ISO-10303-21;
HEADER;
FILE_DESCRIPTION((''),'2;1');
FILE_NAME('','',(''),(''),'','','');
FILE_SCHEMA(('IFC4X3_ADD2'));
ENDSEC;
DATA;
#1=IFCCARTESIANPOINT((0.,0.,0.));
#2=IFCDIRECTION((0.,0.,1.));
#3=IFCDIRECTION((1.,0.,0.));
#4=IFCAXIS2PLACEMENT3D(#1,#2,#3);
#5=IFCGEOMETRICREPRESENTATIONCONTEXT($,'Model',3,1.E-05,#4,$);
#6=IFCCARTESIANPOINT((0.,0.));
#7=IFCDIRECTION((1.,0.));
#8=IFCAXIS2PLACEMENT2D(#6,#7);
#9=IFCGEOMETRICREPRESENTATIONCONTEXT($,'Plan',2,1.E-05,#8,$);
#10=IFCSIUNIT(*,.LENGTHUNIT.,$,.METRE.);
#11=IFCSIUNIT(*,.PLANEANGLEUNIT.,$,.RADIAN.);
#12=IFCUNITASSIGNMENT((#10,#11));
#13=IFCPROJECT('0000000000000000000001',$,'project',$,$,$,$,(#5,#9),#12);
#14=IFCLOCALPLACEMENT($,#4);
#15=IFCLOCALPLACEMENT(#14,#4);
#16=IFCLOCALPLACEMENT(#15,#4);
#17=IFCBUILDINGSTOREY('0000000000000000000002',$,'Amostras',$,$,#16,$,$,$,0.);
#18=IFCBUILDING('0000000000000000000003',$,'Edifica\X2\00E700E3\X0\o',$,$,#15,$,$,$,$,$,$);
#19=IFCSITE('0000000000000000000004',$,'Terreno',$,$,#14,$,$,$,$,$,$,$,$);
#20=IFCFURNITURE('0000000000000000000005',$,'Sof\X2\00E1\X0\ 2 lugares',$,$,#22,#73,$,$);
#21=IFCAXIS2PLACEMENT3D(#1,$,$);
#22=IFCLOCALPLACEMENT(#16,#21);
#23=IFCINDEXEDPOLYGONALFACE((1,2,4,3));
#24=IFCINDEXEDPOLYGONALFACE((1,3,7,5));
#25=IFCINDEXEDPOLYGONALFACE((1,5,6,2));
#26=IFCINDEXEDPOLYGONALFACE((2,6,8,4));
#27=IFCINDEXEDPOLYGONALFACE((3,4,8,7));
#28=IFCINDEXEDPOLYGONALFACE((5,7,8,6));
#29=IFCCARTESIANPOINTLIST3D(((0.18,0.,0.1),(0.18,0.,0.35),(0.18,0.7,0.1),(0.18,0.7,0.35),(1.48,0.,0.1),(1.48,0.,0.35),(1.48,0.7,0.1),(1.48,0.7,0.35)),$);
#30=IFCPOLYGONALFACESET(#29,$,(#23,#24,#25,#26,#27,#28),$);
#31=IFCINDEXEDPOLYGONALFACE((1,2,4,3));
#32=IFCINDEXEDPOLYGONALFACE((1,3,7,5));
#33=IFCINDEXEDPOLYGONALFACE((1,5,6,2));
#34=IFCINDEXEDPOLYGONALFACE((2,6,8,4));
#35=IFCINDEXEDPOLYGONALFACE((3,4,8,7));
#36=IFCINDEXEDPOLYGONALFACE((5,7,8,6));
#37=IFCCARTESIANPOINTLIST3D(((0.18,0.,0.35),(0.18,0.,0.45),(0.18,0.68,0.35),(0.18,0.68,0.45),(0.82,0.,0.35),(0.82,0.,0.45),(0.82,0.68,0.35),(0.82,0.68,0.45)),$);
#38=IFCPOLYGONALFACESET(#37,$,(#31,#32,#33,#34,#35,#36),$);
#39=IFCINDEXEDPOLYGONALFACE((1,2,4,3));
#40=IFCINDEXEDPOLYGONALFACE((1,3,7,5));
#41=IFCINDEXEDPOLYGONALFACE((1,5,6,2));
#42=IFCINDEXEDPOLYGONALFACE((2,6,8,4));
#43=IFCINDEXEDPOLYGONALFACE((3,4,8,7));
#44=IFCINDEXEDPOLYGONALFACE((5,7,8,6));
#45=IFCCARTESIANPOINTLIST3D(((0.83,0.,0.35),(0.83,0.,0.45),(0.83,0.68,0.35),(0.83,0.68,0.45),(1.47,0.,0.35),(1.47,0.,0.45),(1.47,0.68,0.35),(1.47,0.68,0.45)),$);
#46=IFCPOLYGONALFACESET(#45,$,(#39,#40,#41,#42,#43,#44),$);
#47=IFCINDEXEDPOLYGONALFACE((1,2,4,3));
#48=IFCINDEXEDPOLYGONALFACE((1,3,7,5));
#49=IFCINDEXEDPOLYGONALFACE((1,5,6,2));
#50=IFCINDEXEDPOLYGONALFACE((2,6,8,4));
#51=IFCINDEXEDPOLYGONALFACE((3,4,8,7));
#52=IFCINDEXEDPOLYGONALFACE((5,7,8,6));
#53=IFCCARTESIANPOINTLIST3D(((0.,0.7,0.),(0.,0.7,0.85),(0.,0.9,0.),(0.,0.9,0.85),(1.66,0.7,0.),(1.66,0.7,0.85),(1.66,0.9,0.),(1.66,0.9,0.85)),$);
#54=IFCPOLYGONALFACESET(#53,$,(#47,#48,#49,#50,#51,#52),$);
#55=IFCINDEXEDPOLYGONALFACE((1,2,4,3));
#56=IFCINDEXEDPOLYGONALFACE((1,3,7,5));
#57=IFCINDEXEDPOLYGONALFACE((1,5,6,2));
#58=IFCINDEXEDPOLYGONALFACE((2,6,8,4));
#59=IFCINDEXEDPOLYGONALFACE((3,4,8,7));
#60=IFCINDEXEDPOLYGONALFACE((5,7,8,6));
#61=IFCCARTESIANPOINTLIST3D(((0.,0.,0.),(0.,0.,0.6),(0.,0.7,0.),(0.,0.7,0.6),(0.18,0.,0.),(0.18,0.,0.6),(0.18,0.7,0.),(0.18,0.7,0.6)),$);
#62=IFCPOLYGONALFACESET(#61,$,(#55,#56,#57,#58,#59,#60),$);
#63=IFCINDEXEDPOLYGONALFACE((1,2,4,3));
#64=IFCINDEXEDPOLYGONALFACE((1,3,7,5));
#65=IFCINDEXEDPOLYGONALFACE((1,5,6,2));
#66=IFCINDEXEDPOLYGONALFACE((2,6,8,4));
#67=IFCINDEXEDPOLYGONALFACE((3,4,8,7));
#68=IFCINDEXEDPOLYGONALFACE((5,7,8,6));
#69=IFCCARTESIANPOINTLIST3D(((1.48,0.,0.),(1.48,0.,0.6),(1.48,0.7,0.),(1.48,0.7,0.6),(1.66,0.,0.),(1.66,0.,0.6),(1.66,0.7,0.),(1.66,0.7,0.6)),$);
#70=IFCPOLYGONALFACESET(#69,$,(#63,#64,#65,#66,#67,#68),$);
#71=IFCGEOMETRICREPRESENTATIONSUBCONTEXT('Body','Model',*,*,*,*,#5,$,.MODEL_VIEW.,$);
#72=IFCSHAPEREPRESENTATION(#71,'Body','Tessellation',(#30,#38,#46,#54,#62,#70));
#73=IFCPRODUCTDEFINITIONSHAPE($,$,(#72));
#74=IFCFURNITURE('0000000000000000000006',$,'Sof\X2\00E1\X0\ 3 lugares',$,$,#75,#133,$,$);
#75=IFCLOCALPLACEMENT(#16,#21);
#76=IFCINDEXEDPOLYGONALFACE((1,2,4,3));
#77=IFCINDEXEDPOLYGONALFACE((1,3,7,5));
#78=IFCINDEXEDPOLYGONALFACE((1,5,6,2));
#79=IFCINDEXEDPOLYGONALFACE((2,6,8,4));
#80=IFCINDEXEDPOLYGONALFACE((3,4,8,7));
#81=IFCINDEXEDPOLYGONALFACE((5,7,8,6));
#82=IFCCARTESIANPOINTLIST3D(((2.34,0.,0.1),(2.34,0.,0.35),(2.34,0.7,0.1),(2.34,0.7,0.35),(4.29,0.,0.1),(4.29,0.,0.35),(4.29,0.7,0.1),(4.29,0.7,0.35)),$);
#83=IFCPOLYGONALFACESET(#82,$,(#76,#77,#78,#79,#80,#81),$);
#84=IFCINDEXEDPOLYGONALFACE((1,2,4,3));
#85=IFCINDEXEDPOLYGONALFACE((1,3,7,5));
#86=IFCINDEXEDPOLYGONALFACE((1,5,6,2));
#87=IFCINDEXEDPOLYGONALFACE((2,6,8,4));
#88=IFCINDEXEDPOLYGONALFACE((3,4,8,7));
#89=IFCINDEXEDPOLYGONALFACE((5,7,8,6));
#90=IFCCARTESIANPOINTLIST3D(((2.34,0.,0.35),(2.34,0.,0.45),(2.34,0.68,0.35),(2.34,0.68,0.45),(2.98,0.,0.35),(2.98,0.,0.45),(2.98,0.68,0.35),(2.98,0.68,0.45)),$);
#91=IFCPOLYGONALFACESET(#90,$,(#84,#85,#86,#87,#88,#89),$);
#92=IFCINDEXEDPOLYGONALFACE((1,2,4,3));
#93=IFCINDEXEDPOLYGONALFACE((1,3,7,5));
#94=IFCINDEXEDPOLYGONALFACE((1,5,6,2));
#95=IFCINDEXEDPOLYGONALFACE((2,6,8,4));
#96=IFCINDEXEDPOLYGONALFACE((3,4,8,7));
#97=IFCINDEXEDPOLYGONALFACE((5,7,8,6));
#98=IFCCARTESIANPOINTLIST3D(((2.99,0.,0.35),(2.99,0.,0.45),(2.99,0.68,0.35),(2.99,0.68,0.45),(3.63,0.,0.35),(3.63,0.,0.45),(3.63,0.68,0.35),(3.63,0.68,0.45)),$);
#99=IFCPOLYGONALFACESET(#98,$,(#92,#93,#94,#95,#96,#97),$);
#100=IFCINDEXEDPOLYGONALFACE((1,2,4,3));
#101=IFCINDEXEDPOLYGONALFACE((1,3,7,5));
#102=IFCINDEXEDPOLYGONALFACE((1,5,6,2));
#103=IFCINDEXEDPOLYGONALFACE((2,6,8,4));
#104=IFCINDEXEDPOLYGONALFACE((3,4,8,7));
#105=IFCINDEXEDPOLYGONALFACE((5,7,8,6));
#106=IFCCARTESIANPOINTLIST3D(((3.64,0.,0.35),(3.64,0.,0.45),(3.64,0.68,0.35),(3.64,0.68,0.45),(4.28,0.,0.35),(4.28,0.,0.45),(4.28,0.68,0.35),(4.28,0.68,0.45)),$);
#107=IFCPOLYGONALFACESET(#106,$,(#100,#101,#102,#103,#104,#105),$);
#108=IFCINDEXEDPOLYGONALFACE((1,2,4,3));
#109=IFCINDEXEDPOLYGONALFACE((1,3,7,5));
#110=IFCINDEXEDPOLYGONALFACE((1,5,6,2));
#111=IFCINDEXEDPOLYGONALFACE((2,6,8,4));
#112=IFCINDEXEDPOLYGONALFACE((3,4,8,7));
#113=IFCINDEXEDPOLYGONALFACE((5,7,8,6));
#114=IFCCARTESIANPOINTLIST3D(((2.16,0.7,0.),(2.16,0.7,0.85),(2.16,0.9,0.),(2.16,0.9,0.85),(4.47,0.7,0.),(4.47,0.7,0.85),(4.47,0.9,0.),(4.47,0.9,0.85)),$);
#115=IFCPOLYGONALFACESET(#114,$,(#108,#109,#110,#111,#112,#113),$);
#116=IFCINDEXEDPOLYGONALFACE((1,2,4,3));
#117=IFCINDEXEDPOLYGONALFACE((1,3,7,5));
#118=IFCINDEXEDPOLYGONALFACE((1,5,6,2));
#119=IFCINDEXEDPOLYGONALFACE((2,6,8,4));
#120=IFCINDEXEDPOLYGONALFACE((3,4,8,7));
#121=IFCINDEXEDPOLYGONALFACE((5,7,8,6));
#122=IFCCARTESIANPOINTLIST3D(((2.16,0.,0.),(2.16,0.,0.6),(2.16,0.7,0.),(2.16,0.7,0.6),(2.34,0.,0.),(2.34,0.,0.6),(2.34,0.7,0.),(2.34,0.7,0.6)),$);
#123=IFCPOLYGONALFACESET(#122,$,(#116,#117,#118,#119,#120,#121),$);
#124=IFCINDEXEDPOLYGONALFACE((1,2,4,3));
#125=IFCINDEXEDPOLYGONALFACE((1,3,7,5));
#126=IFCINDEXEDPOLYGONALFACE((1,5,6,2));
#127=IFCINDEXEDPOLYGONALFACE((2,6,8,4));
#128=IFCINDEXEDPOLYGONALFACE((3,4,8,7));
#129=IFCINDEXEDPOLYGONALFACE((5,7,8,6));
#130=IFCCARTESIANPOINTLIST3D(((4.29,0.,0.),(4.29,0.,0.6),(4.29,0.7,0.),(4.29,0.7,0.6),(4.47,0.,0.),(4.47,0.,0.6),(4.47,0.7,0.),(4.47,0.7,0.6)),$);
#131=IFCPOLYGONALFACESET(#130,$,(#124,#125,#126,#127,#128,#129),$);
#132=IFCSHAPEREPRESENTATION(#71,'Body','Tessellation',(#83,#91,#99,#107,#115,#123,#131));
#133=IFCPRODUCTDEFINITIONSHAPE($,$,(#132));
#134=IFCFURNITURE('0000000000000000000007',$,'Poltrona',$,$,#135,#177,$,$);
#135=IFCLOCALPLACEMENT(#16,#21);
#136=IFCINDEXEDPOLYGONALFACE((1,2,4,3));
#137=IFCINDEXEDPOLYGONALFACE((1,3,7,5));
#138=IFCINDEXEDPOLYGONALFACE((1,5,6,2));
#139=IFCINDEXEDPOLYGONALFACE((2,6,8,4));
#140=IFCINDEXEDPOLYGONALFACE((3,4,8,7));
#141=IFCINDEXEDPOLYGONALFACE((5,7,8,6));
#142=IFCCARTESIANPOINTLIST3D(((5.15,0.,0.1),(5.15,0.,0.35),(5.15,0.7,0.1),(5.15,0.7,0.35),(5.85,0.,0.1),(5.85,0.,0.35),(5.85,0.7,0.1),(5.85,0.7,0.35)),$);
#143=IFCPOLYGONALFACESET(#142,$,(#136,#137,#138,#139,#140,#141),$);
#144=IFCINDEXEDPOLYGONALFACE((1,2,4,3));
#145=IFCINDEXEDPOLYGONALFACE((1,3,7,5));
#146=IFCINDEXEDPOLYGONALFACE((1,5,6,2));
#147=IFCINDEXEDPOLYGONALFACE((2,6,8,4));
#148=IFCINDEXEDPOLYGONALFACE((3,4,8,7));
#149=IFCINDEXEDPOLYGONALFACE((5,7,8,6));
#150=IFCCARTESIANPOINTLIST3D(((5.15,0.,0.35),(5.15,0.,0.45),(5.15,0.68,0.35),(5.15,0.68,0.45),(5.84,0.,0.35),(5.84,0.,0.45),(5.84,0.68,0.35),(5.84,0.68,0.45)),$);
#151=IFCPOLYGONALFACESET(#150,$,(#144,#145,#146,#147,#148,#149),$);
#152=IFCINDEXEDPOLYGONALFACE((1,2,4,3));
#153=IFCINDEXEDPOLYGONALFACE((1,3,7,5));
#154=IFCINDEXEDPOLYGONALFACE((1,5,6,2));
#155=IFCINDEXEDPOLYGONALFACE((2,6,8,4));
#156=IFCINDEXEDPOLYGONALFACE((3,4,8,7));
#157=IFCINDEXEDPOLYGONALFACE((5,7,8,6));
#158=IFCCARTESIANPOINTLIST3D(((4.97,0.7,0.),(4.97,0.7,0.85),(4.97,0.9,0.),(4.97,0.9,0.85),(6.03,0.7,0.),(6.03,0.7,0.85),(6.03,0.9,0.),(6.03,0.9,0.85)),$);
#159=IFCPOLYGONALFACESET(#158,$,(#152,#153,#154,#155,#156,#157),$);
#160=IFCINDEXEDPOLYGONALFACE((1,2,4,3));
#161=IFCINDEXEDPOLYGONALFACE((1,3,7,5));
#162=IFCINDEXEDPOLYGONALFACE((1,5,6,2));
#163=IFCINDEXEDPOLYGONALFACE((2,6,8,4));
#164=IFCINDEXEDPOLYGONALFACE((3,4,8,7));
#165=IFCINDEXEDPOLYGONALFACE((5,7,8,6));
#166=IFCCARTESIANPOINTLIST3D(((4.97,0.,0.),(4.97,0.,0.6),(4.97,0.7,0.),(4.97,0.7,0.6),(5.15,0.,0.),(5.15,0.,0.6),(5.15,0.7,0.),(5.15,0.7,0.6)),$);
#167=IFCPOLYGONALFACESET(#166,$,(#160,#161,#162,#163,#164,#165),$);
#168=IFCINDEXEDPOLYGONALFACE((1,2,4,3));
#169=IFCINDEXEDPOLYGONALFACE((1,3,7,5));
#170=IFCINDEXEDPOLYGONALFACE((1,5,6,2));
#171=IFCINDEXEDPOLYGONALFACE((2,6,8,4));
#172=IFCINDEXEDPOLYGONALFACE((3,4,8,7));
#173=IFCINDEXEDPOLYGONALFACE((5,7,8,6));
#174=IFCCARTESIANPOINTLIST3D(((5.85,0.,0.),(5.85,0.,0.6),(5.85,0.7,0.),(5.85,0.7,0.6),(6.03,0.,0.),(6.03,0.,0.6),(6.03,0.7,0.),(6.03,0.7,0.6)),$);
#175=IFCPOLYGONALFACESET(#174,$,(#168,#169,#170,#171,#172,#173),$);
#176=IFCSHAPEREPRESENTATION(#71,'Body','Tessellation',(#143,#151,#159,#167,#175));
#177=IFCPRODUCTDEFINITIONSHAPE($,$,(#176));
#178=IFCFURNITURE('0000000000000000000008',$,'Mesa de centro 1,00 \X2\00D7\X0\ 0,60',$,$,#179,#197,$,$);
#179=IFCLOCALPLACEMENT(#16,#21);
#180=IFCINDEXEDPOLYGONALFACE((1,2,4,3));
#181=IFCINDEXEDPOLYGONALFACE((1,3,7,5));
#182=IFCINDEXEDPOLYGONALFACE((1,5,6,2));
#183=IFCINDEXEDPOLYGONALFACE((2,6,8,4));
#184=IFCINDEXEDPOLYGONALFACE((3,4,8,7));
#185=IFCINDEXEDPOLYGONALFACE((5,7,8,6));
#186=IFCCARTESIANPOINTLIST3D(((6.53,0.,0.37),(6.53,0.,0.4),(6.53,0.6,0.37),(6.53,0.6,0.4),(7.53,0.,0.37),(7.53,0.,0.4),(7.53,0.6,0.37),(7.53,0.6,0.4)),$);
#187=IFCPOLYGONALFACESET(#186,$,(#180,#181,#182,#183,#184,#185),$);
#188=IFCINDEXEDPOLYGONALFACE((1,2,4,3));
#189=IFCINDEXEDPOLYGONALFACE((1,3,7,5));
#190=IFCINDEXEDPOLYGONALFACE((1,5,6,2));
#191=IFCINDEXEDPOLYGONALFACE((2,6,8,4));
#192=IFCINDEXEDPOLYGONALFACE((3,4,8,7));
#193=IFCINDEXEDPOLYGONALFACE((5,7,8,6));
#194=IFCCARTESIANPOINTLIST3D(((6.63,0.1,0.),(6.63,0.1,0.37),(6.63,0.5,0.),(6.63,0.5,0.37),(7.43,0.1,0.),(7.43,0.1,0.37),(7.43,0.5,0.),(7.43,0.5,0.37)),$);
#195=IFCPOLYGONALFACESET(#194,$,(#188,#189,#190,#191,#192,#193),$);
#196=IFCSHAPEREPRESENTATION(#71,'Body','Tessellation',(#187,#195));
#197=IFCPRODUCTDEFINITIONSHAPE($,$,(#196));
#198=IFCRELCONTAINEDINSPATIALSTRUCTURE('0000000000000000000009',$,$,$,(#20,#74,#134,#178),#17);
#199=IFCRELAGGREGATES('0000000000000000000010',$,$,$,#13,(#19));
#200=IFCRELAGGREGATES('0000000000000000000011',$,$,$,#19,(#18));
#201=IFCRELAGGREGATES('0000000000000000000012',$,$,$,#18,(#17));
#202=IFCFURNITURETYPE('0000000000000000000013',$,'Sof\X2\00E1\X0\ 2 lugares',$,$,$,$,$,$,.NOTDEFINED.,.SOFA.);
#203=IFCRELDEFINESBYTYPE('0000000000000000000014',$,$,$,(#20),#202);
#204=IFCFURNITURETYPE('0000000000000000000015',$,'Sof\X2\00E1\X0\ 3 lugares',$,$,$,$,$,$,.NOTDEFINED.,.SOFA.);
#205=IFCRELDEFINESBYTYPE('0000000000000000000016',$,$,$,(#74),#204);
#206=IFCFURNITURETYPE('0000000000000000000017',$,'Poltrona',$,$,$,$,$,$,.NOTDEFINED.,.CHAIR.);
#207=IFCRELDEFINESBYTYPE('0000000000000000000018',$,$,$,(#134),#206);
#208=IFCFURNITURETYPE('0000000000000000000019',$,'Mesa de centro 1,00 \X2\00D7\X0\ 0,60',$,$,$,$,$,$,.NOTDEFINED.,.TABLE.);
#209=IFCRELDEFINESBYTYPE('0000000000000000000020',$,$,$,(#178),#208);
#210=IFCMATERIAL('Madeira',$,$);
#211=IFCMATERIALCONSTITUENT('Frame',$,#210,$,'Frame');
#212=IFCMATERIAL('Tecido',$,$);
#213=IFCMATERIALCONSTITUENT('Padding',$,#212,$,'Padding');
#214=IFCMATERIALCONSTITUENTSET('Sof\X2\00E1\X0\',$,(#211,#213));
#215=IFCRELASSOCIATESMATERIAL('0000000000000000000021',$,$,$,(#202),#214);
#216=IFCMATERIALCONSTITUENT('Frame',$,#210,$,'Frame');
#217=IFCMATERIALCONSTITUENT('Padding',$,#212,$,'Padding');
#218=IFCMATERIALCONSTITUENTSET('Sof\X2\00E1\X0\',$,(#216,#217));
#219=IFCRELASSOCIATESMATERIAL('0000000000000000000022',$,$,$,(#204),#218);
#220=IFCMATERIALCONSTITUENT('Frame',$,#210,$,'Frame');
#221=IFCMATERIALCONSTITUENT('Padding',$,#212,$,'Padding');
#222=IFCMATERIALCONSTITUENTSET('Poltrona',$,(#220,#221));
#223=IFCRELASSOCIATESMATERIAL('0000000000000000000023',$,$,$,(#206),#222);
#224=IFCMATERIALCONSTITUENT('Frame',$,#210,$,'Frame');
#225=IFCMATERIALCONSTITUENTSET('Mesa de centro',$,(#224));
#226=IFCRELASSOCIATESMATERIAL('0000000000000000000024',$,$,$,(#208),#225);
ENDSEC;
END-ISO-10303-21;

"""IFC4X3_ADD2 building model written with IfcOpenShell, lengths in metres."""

from ifc_helpers import new_model, si_unit, frame, frame_2d, origin, origin_with_axes, origin_2d_with_axis, place, context, subcontext, project, spatial, rectangle, extrude, material, constituent, constituent_set, type_object, element, save


model = new_model("IFC4X3_ADD2")

# Units and contexts
model_context = context("Model", 3, precision=1e-05, world=origin_with_axes())
plan_context = context("Plan", 2, precision=1e-05, world=origin_2d_with_axis())
body_context = subcontext(model_context, "Body", "Model", "MODEL_VIEW")
ifc_project = project(units=[si_unit("LENGTHUNIT", "METRE"), si_unit("PLANEANGLEUNIT", "RADIAN")], contexts=[model_context, plan_context])

# Site, building, storey
site_placement = place(None, origin_with_axes())
site = spatial("IfcSite", under=ifc_project, at=site_placement, Name="Terreno")
building_placement = place(site_placement, origin_with_axes())
building = spatial("IfcBuilding", under=site, at=building_placement, Name="Edificação")
storey_placement = place(building_placement, origin_with_axes())
storey = spatial("IfcBuildingStorey", under=building, at=storey_placement, Name="Amostras", Elevation=0.0)

# Furniture
ifc_material_1 = material(Name="Madeira")
ifc_constituent_1 = constituent(ifc_material_1, Name="Frame", Category="Frame")
ifc_material_2 = material(Name="Tecido")
ifc_constituent_2 = constituent(ifc_material_2, Name="Padding", Category="Padding")
ifc_constituent_set_1 = constituent_set(constituents=[ifc_constituent_1, ifc_constituent_2], Name="Sofá")
furniture_type_1 = type_object("IfcFurnitureType", Name="Sofá 2 lugares", AssemblyPlace="NOTDEFINED", PredefinedType="SOFA", material=ifc_constituent_set_1)
furniture_1_placement = place(storey_placement, origin_with_axes())
element("IfcFurniture", 1, at=furniture_1_placement, inside=storey, type_object=furniture_type_1, Name="Sofá 2 lugares", context=body_context, shape_type="SweptSolid", body=[
    extrude(rectangle(XDim=1.3, YDim=0.7, at=frame_2d((0.83, 0.35), x_axis=(1.0, 0.0))), frame((0.0, 0.0, 0.1)), (0.0, 0.0, 1.0), 0.25),
    extrude(rectangle(XDim=0.64, YDim=0.68, at=frame_2d((0.5, 0.34), x_axis=(1.0, 0.0))), frame((0.0, 0.0, 0.35)), (0.0, 0.0, 1.0), 0.1),
    extrude(rectangle(XDim=0.64, YDim=0.68, at=frame_2d((1.15, 0.34), x_axis=(1.0, 0.0))), frame((0.0, 0.0, 0.35)), (0.0, 0.0, 1.0), 0.1),
    extrude(rectangle(XDim=1.66, YDim=0.2, at=frame_2d((0.83, 0.8), x_axis=(1.0, 0.0))), origin(), (0.0, 0.0, 1.0), 0.85),
    extrude(rectangle(XDim=0.18, YDim=0.7, at=frame_2d((0.09, 0.35), x_axis=(1.0, 0.0))), origin(), (0.0, 0.0, 1.0), 0.6),
    extrude(rectangle(XDim=0.18, YDim=0.7, at=frame_2d((1.57, 0.35), x_axis=(1.0, 0.0))), origin(), (0.0, 0.0, 1.0), 0.6),
])
ifc_constituent_3 = constituent(ifc_material_1, Name="Frame", Category="Frame")
ifc_constituent_4 = constituent(ifc_material_2, Name="Padding", Category="Padding")
ifc_constituent_set_2 = constituent_set(constituents=[ifc_constituent_3, ifc_constituent_4], Name="Sofá")
furniture_type_2 = type_object("IfcFurnitureType", Name="Sofá 3 lugares", AssemblyPlace="NOTDEFINED", PredefinedType="SOFA", material=ifc_constituent_set_2)
furniture_2_placement = place(storey_placement, frame((2.16, 0.0, 0.0), z_axis=(0.0, 0.0, 1.0), x_axis=(1.0, 0.0, 0.0)))
element("IfcFurniture", 2, at=furniture_2_placement, inside=storey, type_object=furniture_type_2, Name="Sofá 3 lugares", context=body_context, shape_type="SweptSolid", body=[
    extrude(rectangle(XDim=1.95, YDim=0.7, at=frame_2d((1.155, 0.35), x_axis=(1.0, 0.0))), frame((0.0, 0.0, 0.1)), (0.0, 0.0, 1.0), 0.25),
    extrude(rectangle(XDim=0.64, YDim=0.68, at=frame_2d((0.5, 0.34), x_axis=(1.0, 0.0))), frame((0.0, 0.0, 0.35)), (0.0, 0.0, 1.0), 0.1),
    extrude(rectangle(XDim=0.64, YDim=0.68, at=frame_2d((1.15, 0.34), x_axis=(1.0, 0.0))), frame((0.0, 0.0, 0.35)), (0.0, 0.0, 1.0), 0.1),
    extrude(rectangle(XDim=0.64, YDim=0.68, at=frame_2d((1.8, 0.34), x_axis=(1.0, 0.0))), frame((0.0, 0.0, 0.35)), (0.0, 0.0, 1.0), 0.1),
    extrude(rectangle(XDim=2.31, YDim=0.2, at=frame_2d((1.155, 0.8), x_axis=(1.0, 0.0))), origin(), (0.0, 0.0, 1.0), 0.85),
    extrude(rectangle(XDim=0.18, YDim=0.7, at=frame_2d((0.09, 0.35), x_axis=(1.0, 0.0))), origin(), (0.0, 0.0, 1.0), 0.6),
    extrude(rectangle(XDim=0.18, YDim=0.7, at=frame_2d((2.22, 0.35), x_axis=(1.0, 0.0))), origin(), (0.0, 0.0, 1.0), 0.6),
])
ifc_constituent_5 = constituent(ifc_material_1, Name="Frame", Category="Frame")
ifc_constituent_6 = constituent(ifc_material_2, Name="Padding", Category="Padding")
ifc_constituent_set_3 = constituent_set(constituents=[ifc_constituent_5, ifc_constituent_6], Name="Poltrona")
furniture_type_3 = type_object("IfcFurnitureType", Name="Poltrona", AssemblyPlace="NOTDEFINED", PredefinedType="CHAIR", material=ifc_constituent_set_3)
furniture_3_placement = place(storey_placement, frame((4.97, 0.0, 0.0), z_axis=(0.0, 0.0, 1.0), x_axis=(1.0, 0.0, 0.0)))
element("IfcFurniture", 3, at=furniture_3_placement, inside=storey, type_object=furniture_type_3, Name="Poltrona", context=body_context, shape_type="SweptSolid", body=[
    extrude(rectangle(XDim=0.7, YDim=0.7, at=frame_2d((0.53, 0.35), x_axis=(1.0, 0.0))), frame((0.0, 0.0, 0.1)), (0.0, 0.0, 1.0), 0.25),
    extrude(rectangle(XDim=0.69, YDim=0.68, at=frame_2d((0.525, 0.34), x_axis=(1.0, 0.0))), frame((0.0, 0.0, 0.35)), (0.0, 0.0, 1.0), 0.1),
    extrude(rectangle(XDim=1.06, YDim=0.2, at=frame_2d((0.53, 0.8), x_axis=(1.0, 0.0))), origin(), (0.0, 0.0, 1.0), 0.85),
    extrude(rectangle(XDim=0.18, YDim=0.7, at=frame_2d((0.09, 0.35), x_axis=(1.0, 0.0))), origin(), (0.0, 0.0, 1.0), 0.6),
    extrude(rectangle(XDim=0.18, YDim=0.7, at=frame_2d((0.97, 0.35), x_axis=(1.0, 0.0))), origin(), (0.0, 0.0, 1.0), 0.6),
])
ifc_constituent_7 = constituent(ifc_material_1, Name="Frame", Category="Frame")
ifc_constituent_set_4 = constituent_set(constituents=[ifc_constituent_7], Name="Mesa de centro")
furniture_type_4 = type_object("IfcFurnitureType", Name="Mesa de centro 1,00 × 0,60", AssemblyPlace="NOTDEFINED", PredefinedType="TABLE", material=ifc_constituent_set_4)
furniture_4_placement = place(storey_placement, frame((6.53, 0.0, 0.0), z_axis=(0.0, 0.0, 1.0), x_axis=(1.0, 0.0, 0.0)))
element("IfcFurniture", 4, at=furniture_4_placement, inside=storey, type_object=furniture_type_4, Name="Mesa de centro 1,00 × 0,60", context=body_context, shape_type="SweptSolid", body=[
    extrude(rectangle(XDim=1.0, YDim=0.6, at=frame_2d((0.5, 0.3), x_axis=(1.0, 0.0))), frame((0.0, 0.0, 0.37)), (0.0, 0.0, 1.0), 0.03),
    extrude(rectangle(XDim=0.8, YDim=0.4, at=frame_2d((0.5, 0.3), x_axis=(1.0, 0.0))), origin(), (0.0, 0.0, 1.0), 0.37),
])

save(model, "model.ifc")
